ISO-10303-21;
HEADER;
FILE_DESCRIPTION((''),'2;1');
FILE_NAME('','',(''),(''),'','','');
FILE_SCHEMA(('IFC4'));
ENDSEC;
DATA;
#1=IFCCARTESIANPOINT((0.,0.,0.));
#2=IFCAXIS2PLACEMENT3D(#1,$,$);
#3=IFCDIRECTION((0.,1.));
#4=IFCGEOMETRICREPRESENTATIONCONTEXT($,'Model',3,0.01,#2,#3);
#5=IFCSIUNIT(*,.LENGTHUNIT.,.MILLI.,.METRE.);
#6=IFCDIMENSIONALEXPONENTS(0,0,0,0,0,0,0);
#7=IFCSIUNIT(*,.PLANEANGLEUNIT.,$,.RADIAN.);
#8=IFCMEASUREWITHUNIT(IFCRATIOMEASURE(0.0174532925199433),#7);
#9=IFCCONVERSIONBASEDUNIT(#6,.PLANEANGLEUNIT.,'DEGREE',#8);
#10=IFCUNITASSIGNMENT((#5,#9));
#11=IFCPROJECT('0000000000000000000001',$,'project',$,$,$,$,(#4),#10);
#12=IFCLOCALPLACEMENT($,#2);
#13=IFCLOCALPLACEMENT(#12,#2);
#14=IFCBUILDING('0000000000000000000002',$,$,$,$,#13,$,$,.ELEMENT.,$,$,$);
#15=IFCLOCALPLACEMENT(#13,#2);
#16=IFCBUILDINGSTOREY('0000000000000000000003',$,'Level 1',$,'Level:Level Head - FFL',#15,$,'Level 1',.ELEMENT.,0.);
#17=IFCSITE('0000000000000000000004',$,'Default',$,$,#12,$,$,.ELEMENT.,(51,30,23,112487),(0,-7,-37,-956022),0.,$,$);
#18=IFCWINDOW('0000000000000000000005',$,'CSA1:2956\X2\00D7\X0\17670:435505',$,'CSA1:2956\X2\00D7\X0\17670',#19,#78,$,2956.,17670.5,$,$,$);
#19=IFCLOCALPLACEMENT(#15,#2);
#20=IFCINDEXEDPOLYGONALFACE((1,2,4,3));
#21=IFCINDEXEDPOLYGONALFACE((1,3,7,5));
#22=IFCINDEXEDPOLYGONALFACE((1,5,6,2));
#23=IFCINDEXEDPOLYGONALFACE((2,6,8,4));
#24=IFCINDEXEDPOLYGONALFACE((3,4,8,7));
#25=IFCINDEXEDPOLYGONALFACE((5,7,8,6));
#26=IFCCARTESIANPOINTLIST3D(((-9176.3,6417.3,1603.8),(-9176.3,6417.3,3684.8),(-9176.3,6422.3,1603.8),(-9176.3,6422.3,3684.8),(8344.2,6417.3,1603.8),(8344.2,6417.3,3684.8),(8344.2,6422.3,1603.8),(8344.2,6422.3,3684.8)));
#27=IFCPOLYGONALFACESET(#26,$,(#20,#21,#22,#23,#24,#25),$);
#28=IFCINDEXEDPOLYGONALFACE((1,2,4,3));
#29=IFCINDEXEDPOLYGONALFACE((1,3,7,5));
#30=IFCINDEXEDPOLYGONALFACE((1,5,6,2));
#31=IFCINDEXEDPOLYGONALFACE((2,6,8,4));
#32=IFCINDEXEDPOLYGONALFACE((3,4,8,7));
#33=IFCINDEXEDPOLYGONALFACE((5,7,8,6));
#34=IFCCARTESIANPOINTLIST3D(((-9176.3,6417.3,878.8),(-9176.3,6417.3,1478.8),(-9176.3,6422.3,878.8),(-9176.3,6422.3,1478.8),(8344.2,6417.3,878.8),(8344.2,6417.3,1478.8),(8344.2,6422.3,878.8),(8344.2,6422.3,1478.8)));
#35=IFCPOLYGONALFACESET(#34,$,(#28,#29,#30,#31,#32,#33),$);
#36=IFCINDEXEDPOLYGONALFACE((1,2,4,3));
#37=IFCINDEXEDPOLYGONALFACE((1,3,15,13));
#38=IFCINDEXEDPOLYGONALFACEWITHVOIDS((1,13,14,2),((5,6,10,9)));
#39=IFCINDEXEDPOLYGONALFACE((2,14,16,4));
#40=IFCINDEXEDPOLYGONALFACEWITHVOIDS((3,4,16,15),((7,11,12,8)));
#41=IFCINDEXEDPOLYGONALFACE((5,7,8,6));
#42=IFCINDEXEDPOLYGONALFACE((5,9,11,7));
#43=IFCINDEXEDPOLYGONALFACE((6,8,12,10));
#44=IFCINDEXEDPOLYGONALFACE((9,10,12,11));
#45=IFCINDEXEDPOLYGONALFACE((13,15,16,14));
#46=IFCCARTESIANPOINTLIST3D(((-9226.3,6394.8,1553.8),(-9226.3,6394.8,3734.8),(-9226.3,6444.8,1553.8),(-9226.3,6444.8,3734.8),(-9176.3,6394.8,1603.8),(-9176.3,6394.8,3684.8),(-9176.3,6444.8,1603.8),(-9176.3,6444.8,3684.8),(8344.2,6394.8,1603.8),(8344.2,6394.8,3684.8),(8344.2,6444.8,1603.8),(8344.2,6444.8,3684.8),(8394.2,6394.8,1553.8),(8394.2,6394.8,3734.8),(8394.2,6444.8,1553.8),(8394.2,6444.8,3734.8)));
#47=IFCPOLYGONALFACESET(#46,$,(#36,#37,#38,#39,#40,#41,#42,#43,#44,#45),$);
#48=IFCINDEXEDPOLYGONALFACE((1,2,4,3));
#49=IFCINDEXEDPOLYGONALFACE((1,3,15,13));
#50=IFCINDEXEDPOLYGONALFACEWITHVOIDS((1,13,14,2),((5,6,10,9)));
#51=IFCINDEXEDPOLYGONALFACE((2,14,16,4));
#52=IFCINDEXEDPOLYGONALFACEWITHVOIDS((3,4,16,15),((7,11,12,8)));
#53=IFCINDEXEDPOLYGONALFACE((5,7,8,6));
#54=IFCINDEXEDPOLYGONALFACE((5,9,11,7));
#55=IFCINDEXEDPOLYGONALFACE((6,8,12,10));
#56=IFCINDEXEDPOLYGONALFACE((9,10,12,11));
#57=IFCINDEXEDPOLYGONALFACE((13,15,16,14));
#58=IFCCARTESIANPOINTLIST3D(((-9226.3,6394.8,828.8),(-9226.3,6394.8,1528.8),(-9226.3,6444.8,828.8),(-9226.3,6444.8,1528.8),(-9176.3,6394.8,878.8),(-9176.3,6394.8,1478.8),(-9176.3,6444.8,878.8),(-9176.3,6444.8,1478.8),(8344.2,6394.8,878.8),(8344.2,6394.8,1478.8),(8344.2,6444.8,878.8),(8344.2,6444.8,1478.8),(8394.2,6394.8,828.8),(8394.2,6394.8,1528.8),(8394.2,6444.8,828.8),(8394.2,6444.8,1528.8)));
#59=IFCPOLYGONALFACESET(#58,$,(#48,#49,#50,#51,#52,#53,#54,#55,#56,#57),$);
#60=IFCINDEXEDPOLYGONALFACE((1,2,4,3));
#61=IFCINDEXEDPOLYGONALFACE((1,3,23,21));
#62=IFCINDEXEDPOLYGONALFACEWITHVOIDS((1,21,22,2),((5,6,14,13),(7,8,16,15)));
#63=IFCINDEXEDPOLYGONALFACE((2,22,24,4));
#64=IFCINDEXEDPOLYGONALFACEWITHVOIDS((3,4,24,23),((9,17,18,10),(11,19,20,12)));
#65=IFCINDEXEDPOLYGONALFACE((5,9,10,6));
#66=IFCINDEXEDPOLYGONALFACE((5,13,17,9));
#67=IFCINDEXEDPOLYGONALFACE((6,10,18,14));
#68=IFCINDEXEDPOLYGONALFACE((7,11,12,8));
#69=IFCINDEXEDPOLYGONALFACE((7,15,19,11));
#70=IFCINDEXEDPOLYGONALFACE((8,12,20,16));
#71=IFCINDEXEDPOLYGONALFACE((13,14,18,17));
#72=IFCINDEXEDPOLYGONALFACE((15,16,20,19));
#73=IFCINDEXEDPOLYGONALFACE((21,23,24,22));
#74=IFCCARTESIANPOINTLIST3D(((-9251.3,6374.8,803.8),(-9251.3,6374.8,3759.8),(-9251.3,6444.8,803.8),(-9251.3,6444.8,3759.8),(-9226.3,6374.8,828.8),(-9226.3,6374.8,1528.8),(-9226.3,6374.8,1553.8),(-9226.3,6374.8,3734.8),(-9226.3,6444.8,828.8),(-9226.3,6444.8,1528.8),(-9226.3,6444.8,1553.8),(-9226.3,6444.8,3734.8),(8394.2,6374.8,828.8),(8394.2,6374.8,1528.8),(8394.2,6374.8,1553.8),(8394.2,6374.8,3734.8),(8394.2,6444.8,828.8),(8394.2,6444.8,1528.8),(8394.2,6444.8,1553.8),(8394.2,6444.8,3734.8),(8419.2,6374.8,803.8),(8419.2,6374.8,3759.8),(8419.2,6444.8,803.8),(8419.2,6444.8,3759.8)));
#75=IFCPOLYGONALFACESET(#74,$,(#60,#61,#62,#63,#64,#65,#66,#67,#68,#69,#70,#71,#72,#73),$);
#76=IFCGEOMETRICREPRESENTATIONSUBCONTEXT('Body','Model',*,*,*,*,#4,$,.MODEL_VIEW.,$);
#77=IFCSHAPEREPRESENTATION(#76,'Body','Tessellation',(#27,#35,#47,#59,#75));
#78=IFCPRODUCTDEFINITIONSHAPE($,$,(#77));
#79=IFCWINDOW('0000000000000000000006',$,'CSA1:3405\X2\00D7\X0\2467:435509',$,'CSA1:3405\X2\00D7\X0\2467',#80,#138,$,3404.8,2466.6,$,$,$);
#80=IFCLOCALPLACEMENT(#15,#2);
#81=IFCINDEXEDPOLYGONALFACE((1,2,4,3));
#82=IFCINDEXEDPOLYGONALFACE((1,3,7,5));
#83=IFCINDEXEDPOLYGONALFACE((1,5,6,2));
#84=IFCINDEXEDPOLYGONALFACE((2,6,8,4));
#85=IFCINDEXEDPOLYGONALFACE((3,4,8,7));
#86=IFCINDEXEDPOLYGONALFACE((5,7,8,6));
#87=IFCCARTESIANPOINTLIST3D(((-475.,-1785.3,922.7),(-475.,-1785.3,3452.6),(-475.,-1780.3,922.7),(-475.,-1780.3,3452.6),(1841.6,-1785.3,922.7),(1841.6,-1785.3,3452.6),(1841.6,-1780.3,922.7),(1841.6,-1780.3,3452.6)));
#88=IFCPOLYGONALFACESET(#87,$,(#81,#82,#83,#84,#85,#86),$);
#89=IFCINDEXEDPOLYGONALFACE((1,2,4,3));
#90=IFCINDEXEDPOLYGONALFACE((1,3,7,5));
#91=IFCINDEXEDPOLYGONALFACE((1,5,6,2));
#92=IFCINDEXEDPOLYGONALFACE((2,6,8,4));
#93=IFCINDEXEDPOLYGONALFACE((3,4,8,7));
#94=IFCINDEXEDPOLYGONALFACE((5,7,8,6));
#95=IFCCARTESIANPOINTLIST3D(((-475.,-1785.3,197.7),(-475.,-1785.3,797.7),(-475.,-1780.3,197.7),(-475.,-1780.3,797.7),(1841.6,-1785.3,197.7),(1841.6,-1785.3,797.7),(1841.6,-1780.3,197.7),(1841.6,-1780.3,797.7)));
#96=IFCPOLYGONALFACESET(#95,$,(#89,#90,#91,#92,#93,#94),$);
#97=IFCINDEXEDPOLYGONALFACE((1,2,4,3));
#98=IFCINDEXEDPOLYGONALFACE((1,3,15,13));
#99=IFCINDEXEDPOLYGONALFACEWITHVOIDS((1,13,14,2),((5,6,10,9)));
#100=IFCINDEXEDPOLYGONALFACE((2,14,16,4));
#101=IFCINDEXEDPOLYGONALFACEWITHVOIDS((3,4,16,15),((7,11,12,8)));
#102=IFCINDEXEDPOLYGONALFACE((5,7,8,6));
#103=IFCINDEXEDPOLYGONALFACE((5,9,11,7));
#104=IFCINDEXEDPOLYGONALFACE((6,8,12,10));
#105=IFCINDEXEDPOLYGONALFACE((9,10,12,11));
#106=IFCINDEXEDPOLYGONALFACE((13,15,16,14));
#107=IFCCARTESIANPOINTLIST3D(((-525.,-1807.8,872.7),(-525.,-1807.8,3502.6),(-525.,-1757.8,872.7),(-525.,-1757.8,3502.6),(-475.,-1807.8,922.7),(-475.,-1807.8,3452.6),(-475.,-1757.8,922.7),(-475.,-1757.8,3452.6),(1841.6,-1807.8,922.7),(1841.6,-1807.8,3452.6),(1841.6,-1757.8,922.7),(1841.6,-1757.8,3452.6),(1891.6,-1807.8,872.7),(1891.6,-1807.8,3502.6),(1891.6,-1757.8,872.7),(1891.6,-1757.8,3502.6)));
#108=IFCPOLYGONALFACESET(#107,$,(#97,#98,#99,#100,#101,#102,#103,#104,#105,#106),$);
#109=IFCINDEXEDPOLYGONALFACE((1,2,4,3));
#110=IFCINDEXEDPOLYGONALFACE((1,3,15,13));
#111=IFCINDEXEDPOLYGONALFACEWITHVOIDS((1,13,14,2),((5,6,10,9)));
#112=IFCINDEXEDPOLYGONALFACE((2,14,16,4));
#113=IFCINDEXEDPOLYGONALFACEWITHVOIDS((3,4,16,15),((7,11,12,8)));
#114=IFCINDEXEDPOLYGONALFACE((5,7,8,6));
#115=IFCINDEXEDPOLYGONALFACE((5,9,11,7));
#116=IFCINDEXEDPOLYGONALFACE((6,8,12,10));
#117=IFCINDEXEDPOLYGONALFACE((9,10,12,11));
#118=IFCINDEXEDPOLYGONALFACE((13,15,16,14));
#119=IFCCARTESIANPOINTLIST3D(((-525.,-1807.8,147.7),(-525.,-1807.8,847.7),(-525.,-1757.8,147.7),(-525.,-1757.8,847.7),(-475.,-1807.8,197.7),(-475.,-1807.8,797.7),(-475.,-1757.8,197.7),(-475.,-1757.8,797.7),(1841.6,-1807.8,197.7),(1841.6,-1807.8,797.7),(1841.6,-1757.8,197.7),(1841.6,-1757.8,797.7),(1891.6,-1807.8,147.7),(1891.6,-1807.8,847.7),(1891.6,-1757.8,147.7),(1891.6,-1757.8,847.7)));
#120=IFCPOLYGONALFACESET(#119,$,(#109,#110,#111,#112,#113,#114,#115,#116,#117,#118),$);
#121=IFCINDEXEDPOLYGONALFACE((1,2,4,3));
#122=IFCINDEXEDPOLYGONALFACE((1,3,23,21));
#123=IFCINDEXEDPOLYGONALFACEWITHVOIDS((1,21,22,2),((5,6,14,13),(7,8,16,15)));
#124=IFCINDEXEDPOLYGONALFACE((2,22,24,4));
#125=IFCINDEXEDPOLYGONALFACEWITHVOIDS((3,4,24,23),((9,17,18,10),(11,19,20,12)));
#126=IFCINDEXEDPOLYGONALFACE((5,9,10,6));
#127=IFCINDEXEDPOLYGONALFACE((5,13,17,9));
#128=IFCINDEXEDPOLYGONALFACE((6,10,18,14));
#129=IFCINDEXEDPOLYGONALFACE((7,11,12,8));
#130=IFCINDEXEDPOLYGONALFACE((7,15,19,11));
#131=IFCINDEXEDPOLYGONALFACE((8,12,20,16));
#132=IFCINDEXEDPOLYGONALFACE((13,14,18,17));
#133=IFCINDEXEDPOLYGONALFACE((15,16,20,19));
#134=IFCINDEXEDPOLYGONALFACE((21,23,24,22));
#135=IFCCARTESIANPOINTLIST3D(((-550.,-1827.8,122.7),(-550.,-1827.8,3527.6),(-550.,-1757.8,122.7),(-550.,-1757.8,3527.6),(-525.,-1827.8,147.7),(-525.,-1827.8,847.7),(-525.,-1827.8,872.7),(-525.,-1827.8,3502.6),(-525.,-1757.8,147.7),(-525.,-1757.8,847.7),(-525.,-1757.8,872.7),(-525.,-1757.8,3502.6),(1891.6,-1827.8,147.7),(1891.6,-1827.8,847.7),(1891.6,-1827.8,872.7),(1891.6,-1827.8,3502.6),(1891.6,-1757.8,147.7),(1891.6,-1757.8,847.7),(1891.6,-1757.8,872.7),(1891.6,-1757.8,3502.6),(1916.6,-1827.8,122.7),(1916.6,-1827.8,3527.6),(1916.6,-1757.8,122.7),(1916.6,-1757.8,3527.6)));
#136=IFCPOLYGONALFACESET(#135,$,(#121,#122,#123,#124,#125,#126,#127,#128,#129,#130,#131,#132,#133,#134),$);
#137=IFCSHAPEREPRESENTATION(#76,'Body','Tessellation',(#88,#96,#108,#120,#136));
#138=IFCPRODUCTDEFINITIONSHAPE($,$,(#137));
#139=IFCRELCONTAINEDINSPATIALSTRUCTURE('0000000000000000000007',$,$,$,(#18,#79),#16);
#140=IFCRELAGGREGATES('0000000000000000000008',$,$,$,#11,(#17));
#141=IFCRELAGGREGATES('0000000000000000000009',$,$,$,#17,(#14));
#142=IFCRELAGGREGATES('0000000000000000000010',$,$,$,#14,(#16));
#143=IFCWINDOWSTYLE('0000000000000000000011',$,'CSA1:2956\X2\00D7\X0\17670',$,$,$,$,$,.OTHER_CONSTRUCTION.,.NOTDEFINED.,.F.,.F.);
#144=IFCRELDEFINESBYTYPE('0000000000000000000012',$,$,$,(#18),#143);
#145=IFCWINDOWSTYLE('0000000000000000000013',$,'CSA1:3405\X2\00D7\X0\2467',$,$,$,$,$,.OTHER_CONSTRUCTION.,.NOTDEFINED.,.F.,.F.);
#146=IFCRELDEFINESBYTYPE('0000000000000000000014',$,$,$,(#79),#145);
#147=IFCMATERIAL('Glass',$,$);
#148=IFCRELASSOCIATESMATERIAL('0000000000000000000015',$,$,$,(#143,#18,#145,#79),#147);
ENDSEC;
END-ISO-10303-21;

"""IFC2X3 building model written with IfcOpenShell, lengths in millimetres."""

from ifc_helpers import new_model, entity, si_unit, converted_unit, direction, frame, frame_2d, origin, origin_2d_with_axis, place, context, subcontext, project, spatial, polyline, rectangle, outline, extrude, source, transform, mapped, material, type_object, type_shapes, element, save


model = new_model("IFC2X3")

# Units and contexts
model_context = context("Model", 3, precision=0.01, world=origin(), true_north=direction((0.0, 1.0)))
body_context = subcontext(model_context, "Body", "Model", "MODEL_VIEW")
ifc_project = project(units=[si_unit("LENGTHUNIT", "METRE", prefix="MILLI"), converted_unit("PLANEANGLEUNIT", "DEGREE", entity("IfcRatioMeasure", 0.0174532925199433), si_unit("PLANEANGLEUNIT", "RADIAN"), dimensions=[0, 0, 0, 0, 0, 0, 0])], contexts=[model_context])

# Site, building, storey
site_placement = place(None, origin())
site = spatial("IfcSite", under=ifc_project, at=site_placement, Name="Default", CompositionType="ELEMENT", RefLatitude=(51, 30, 23, 112487), RefLongitude=(0, -7, -37, -956022), RefElevation=0.0)
building_placement = place(site_placement, origin())
building = spatial("IfcBuilding", under=site, at=building_placement, CompositionType="ELEMENT")
storey_placement = place(building_placement, origin())
storey = spatial("IfcBuildingStorey", under=building, at=storey_placement, Name="Level 1", ObjectType="Level:Level Head - FFL", LongName="Level 1", CompositionType="ELEMENT", Elevation=0.0)

# Windows
ifc_material_1 = material(Name="Glass")
window_style_1 = type_object("IfcWindowStyle", Name="CSA1:2956×17670", ConstructionType="OTHER_CONSTRUCTION", OperationType="NOTDEFINED", ParameterTakesPrecedence=False, Sizeable=False, material=ifc_material_1)
shared_shape_1 = source(origin(), body_context, "Body", "SweptSolid", [
    extrude(rectangle(XDim=5.0, YDim=17520.5, at=frame_2d((0.0, 0.0), x_axis=(1.0, 0.0))), frame((8835.2, 45.0, 800.0), z_axis=(0.0, 0.0, 1.0), x_axis=(0.0, 1.0, 0.0)), (0.0, 0.0, 1.0), 2081.0),
    extrude(rectangle(XDim=5.0, YDim=17520.5, at=frame_2d((0.0, 0.0), x_axis=(1.0, 0.0))), frame((8835.2, 45.0, 75.0), z_axis=(0.0, 0.0, 1.0), x_axis=(0.0, 1.0, 0.0)), (0.0, 0.0, 1.0), 600.0),
    extrude(outline(polyline([(-8810.2, -1090.5), (8810.2, -1090.5), (8810.2, 1090.5), (-8810.2, 1090.5), (-8810.2, -1090.5)]), holes=[polyline([(-8760.2, -1040.5), (-8760.2, 1040.5), (8760.2, 1040.5), (8760.2, -1040.5), (-8760.2, -1040.5)])]), frame((8835.2, 20.0, 1840.5), z_axis=(0.0, 1.0, 0.0), x_axis=(1.0, 0.0, 0.0)), (0.0, 0.0, 1.0), 50.0),
    extrude(outline(polyline([(-8810.2, -350.0), (8810.2, -350.0), (8810.2, 350.0), (-8810.2, 350.0), (-8810.2, -350.0)]), holes=[polyline([(-8760.2, -300.0), (-8760.2, 300.0), (8760.2, 300.0), (8760.2, -300.0), (-8760.2, -300.0)])]), frame((8835.2, 20.0, 375.0), z_axis=(0.0, 1.0, 0.0), x_axis=(1.0, 0.0, 0.0)), (0.0, 0.0, 1.0), 50.0),
    extrude(outline(polyline([(-8835.2, -1478.0), (8835.2, -1478.0), (8835.2, 1478.0), (-8835.2, 1478.0), (-8835.2, -1478.0)]), holes=[polyline([(-8810.2, -1453.0), (-8810.2, 728.0), (8810.2, 728.0), (8810.2, -1453.0), (-8810.2, -1453.0)]), polyline([(-8810.2, 753.0), (-8810.2, 1453.0), (8810.2, 1453.0), (8810.2, 753.0), (-8810.2, 753.0)])]), frame((8835.2, 0.0, 1478.0), z_axis=(0.0, 1.0, 0.0), x_axis=(1.0, 0.0, 0.0)), (0.0, 0.0, 1.0), 70.0),
])
type_shapes(window_style_1, [shared_shape_1])
window_1_placement = place(storey_placement, frame((-9251.3, 6374.8, 803.8)))
element("IfcWindow", 1, at=window_1_placement, inside=storey, type_object=window_style_1, material=ifc_material_1, Name="CSA1:2956×17670:435505", ObjectType="CSA1:2956×17670", OverallHeight=2956.0, OverallWidth=17670.5, context=body_context, shape_type="MappedRepresentation", body=[
    mapped(shared_shape_1, transform((0.0, 0.0, 0.0), scale=1.0)),
])
window_style_2 = type_object("IfcWindowStyle", Name="CSA1:3405×2467", ConstructionType="OTHER_CONSTRUCTION", OperationType="NOTDEFINED", ParameterTakesPrecedence=False, Sizeable=False, material=ifc_material_1)
shared_shape_2 = source(origin(), body_context, "Body", "SweptSolid", [
    extrude(rectangle(XDim=5.0, YDim=2316.6, at=origin_2d_with_axis()), frame((1233.3, 45.0, 800.0), z_axis=(0.0, 0.0, 1.0), x_axis=(0.0, 1.0, 0.0)), (0.0, 0.0, 1.0), 2529.8),
    extrude(rectangle(XDim=5.0, YDim=2316.6, at=origin_2d_with_axis()), frame((1233.3, 45.0, 75.0), z_axis=(0.0, 0.0, 1.0), x_axis=(0.0, 1.0, 0.0)), (0.0, 0.0, 1.0), 600.0),
    extrude(outline(polyline([(-1208.3, -1314.9), (1208.3, -1314.9), (1208.3, 1314.9), (-1208.3, 1314.9), (-1208.3, -1314.9)]), holes=[polyline([(-1158.3, -1264.9), (-1158.3, 1264.9), (1158.3, 1264.9), (1158.3, -1264.9), (-1158.3, -1264.9)])]), frame((1233.3, 20.0, 2064.9), z_axis=(0.0, 1.0, 0.0), x_axis=(1.0, 0.0, 0.0)), (0.0, 0.0, 1.0), 50.0),
    extrude(outline(polyline([(-1208.3, -350.0), (1208.3, -350.0), (1208.3, 350.0), (-1208.3, 350.0), (-1208.3, -350.0)]), holes=[polyline([(-1158.3, -300.0), (-1158.3, 300.0), (1158.3, 300.0), (1158.3, -300.0), (-1158.3, -300.0)])]), frame((1233.3, 20.0, 375.0), z_axis=(0.0, 1.0, 0.0), x_axis=(1.0, 0.0, 0.0)), (0.0, 0.0, 1.0), 50.0),
    extrude(outline(polyline([(-1233.3, -1702.4), (1233.3, -1702.4), (1233.3, 1702.4), (-1233.3, 1702.4), (-1233.3, -1702.4)]), holes=[polyline([(-1208.3, -1677.4), (-1208.3, 952.4), (1208.3, 952.4), (1208.3, -1677.4), (-1208.3, -1677.4)]), polyline([(-1208.3, 977.4), (-1208.3, 1677.4), (1208.3, 1677.4), (1208.3, 977.4), (-1208.3, 977.4)])]), frame((1233.3, 0.0, 1702.4), z_axis=(0.0, 1.0, 0.0), x_axis=(1.0, 0.0, 0.0)), (0.0, 0.0, 1.0), 70.0),
])
type_shapes(window_style_2, [shared_shape_2])
window_2_placement = place(storey_placement, frame((-550.0, -1827.8, 122.7)))
element("IfcWindow", 2, at=window_2_placement, inside=storey, type_object=window_style_2, material=ifc_material_1, Name="CSA1:3405×2467:435509", ObjectType="CSA1:3405×2467", OverallHeight=3404.8, OverallWidth=2466.6, context=body_context, shape_type="MappedRepresentation", body=[
    mapped(shared_shape_2, transform((0.0, 0.0, 0.0), scale=1.0)),
])

save(model, "model.ifc")
